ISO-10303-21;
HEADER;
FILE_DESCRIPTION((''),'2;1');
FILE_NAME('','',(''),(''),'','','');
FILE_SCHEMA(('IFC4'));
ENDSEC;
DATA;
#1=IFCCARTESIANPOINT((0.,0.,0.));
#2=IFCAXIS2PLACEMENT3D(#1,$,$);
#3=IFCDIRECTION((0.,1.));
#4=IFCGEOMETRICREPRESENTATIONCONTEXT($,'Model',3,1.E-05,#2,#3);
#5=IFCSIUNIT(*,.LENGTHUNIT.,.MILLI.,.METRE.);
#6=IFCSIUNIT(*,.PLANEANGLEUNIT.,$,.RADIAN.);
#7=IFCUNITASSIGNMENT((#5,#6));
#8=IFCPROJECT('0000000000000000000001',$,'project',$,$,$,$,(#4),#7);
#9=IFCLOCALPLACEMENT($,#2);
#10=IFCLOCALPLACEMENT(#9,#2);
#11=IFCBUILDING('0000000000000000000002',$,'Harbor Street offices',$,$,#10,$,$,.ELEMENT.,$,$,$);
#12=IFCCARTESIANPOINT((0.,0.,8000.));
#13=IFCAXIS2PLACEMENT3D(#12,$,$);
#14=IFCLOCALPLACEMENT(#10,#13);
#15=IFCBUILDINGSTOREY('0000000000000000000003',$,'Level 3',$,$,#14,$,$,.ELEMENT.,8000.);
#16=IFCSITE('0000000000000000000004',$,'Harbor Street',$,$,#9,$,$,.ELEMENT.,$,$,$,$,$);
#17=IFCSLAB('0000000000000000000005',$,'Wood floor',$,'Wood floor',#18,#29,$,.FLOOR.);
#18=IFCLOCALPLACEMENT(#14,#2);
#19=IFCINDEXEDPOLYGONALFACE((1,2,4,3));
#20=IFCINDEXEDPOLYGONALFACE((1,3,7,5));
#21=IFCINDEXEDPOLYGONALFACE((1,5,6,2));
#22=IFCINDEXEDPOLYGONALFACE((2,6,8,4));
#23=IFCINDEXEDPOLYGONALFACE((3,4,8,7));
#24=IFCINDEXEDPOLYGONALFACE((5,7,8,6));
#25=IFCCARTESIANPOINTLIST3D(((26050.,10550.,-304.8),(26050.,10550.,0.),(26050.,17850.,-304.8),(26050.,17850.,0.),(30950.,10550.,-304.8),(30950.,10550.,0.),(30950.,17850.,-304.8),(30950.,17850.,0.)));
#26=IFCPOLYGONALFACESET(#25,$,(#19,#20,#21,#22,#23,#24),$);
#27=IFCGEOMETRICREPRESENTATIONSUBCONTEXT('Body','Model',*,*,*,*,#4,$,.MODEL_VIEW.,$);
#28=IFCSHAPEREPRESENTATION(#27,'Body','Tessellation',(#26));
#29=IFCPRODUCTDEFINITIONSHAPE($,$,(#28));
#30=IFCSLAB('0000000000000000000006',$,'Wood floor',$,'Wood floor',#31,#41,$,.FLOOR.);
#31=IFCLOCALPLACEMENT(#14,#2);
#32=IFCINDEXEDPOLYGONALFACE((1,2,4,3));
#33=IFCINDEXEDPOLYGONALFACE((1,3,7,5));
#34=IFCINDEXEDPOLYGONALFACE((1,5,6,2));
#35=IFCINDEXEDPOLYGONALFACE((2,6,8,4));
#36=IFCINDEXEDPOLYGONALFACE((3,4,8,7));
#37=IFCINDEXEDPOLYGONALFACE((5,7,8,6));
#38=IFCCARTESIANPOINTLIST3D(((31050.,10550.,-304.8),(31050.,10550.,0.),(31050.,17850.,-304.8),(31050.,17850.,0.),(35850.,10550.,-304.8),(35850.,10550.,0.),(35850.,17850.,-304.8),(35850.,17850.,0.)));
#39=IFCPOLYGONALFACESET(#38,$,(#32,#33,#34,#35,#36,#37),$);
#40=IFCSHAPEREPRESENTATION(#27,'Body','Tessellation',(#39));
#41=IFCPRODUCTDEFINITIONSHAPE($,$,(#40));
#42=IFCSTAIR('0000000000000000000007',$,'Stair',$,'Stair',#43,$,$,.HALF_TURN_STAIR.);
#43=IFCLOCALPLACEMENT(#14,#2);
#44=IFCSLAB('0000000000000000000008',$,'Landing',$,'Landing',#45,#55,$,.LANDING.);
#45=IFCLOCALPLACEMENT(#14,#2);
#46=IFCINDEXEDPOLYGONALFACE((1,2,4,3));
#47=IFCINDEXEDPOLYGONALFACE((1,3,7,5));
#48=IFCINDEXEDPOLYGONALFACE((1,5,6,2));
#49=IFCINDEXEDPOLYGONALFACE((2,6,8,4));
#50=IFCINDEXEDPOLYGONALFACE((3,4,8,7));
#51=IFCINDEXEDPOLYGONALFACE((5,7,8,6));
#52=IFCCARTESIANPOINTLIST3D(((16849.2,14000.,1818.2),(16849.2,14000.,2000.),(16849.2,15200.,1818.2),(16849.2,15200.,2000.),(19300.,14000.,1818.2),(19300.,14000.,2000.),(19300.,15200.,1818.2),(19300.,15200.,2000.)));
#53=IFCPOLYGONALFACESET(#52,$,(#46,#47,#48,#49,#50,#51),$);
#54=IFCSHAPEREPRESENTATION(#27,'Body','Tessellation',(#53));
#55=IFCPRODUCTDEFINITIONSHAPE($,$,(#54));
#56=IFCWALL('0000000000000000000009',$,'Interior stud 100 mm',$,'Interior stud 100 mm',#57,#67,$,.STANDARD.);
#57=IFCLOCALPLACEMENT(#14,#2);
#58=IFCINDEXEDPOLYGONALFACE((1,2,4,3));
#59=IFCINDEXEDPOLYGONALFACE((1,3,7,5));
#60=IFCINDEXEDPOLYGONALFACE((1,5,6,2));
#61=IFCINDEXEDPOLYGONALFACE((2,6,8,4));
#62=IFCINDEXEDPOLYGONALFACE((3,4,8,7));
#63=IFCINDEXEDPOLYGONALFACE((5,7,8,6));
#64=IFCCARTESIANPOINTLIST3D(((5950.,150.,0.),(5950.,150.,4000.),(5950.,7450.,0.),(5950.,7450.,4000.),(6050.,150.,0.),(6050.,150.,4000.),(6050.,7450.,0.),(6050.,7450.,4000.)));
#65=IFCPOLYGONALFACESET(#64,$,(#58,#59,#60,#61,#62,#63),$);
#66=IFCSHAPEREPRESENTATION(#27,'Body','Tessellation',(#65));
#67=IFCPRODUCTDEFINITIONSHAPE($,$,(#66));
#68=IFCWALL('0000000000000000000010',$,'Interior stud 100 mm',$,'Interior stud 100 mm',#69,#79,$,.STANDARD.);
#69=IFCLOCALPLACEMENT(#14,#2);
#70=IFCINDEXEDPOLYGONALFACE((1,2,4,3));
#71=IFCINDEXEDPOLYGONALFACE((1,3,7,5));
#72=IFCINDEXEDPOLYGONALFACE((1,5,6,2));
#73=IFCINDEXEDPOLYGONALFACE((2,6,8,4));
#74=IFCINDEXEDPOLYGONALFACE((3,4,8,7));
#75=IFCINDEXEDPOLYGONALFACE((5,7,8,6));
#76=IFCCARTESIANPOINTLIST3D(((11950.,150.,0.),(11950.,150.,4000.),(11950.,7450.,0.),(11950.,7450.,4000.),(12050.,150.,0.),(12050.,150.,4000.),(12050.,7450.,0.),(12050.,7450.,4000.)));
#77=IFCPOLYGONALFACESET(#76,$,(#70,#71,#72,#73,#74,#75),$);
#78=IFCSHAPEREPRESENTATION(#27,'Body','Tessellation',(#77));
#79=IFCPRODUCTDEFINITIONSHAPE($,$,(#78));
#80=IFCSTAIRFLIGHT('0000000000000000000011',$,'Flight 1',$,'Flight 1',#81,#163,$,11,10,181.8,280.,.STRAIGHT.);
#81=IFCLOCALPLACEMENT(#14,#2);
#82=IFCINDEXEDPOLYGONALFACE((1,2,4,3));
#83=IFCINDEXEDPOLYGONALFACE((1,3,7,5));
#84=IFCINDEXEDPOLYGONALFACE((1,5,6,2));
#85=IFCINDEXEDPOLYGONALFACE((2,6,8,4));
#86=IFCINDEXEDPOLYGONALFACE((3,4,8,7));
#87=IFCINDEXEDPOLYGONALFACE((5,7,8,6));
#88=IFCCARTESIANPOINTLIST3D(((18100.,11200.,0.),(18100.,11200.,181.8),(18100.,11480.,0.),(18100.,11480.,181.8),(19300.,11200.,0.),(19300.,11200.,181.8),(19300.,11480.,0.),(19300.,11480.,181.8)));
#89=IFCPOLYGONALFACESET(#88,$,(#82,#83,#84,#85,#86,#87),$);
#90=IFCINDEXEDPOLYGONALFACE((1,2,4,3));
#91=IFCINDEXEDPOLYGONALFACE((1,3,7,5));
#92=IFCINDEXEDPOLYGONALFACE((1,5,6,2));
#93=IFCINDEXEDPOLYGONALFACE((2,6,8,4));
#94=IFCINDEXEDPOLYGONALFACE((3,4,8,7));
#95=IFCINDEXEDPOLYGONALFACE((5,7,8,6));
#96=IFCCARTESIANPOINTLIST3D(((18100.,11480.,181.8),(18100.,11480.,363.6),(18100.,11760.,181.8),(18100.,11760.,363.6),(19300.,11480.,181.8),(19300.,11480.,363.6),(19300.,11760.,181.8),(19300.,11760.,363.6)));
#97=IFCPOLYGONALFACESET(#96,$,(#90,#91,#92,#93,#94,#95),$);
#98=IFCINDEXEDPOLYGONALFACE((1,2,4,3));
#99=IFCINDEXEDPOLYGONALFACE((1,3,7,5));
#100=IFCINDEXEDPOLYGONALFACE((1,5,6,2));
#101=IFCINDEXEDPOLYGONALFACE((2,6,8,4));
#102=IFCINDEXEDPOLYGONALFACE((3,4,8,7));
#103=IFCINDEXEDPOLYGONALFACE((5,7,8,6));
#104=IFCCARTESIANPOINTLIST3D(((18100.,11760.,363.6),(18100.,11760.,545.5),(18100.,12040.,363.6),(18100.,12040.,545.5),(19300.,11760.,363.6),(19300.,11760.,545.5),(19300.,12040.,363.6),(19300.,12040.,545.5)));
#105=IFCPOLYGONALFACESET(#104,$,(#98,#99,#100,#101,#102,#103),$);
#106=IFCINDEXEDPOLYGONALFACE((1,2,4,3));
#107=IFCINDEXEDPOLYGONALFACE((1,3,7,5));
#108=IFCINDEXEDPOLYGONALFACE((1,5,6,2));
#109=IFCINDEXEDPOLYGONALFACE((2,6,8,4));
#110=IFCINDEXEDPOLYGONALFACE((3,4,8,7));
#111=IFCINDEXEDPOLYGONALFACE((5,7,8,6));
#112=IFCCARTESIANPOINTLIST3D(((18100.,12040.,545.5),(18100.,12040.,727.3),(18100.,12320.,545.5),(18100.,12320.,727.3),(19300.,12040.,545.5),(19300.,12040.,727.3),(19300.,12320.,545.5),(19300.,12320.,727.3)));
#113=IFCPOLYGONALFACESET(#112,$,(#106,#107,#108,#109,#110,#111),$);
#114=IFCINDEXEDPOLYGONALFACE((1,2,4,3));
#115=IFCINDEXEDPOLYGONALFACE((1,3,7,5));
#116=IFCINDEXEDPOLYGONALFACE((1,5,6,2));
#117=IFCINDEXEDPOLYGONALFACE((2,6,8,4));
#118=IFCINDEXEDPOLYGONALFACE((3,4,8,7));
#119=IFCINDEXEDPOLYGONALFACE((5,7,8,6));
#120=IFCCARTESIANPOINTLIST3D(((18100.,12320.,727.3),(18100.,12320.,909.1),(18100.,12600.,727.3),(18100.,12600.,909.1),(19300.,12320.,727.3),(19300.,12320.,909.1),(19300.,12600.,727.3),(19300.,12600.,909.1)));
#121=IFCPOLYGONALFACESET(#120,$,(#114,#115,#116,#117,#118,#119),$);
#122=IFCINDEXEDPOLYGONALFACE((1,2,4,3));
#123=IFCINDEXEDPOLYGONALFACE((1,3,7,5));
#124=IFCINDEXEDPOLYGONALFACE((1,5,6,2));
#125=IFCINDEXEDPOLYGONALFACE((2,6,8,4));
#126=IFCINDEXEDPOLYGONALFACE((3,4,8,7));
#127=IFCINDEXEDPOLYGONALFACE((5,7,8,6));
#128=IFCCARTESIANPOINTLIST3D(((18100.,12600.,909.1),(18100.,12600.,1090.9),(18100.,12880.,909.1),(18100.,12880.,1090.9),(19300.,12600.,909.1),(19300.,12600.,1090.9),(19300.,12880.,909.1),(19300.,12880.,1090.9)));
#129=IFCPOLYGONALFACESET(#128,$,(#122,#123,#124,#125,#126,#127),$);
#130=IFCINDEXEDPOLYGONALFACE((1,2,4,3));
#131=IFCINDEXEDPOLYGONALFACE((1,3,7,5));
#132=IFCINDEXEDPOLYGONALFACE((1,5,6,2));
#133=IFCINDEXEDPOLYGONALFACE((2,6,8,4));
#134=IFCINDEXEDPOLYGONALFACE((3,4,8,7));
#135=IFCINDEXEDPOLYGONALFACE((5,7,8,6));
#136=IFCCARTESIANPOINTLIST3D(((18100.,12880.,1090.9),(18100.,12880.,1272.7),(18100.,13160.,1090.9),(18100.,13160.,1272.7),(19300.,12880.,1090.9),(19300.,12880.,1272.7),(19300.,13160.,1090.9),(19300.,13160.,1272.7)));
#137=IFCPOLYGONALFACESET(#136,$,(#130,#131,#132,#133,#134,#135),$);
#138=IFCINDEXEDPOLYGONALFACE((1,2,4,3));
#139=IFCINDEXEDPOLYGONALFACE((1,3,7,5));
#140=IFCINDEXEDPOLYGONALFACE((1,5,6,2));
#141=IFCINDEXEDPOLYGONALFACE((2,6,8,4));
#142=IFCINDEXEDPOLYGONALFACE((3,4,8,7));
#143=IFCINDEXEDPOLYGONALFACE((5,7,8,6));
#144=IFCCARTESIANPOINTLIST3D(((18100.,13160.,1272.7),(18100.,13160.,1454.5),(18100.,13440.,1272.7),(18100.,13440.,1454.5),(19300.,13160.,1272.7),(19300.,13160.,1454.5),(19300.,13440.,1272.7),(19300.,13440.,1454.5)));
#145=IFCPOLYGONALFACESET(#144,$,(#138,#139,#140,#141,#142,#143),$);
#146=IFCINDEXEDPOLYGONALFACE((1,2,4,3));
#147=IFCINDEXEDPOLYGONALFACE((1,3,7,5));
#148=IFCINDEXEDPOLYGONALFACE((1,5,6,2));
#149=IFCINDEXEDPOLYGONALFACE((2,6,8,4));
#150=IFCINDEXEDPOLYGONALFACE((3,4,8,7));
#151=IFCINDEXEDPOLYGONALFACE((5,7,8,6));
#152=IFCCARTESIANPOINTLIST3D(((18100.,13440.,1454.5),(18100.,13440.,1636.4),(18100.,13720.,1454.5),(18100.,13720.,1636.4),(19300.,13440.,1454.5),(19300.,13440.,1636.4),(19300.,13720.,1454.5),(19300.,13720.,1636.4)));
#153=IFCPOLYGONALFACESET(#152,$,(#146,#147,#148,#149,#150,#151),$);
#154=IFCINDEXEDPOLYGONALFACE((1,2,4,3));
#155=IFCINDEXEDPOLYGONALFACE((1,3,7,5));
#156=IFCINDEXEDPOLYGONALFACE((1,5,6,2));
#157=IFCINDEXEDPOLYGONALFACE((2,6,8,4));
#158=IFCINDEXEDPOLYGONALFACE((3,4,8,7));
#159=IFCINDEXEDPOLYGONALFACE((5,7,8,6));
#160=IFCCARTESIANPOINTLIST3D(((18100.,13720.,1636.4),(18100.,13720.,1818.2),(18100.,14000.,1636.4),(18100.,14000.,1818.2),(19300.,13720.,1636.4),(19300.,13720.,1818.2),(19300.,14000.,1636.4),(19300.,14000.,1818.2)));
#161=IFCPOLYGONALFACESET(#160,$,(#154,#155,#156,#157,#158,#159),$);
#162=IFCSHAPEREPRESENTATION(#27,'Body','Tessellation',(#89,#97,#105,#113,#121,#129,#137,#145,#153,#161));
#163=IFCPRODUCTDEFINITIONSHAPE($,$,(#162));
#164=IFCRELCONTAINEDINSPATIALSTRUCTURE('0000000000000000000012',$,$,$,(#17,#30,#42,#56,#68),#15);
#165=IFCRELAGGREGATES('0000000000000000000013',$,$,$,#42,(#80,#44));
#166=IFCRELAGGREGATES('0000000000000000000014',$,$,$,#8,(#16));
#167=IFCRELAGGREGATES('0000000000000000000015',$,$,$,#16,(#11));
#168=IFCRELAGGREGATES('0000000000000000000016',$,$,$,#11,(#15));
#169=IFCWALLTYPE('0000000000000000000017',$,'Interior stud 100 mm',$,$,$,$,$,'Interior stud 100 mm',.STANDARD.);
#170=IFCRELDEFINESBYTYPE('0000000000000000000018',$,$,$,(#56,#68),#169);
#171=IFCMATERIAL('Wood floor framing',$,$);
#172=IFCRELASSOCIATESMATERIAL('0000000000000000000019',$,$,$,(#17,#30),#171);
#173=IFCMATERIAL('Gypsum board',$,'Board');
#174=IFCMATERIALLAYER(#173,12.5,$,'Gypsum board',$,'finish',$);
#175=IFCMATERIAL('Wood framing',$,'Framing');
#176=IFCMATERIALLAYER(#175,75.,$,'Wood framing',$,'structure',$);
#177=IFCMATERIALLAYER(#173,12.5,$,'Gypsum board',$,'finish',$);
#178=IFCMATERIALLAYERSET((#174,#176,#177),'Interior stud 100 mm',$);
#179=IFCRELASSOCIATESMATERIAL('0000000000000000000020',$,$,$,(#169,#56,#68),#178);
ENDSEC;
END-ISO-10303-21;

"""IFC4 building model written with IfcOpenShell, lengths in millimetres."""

from ifc_helpers import new_model, si_unit, direction, frame, origin, origin_with_axes, place, context, subcontext, project, spatial, polyline, outline, extrude, material, layer, layer_set, layer_usage, type_object, element, aggregate, save


model = new_model("IFC4")

# Units and contexts
model_context = context("Model", 3, precision=1e-05, world=origin(), true_north=direction((0.0, 1.0)))
body_context = subcontext(model_context, "Body", "Model", "MODEL_VIEW")
ifc_project = project(units=[si_unit("LENGTHUNIT", "METRE", prefix="MILLI"), si_unit("PLANEANGLEUNIT", "RADIAN")], contexts=[model_context])

# Site, building, storey
site_placement = place(None, origin())
site = spatial("IfcSite", under=ifc_project, at=site_placement, Name="Harbor Street", CompositionType="ELEMENT")
building_placement = place(site_placement, origin())
building = spatial("IfcBuilding", under=site, at=building_placement, Name="Harbor Street offices", CompositionType="ELEMENT")
storey_placement = place(building_placement, frame((0.0, 0.0, 8000.0)))
storey = spatial("IfcBuildingStorey", under=building, at=storey_placement, Name="Level 3", CompositionType="ELEMENT", Elevation=8000.0)

# Slabs
ifc_material_1 = material(Name="Wood floor framing")
slab_1_placement = place(storey_placement, origin_with_axes())
element("IfcSlab", 1, at=slab_1_placement, inside=storey, material=ifc_material_1, Name="Wood floor", ObjectType="Wood floor", PredefinedType="FLOOR", context=body_context, shape_type="SweptSolid", body=[
    extrude(outline(polyline([(30950.0, 17850.0), (26050.0, 17850.0), (26050.0, 10550.0), (30950.0, 10550.0), (30950.0, 17850.0)])), frame((0.0, 0.0, -304.8)), (0.0, 0.0, 1.0), 304.8),
])
slab_2_placement = place(storey_placement, origin_with_axes())
element("IfcSlab", 2, at=slab_2_placement, inside=storey, material=ifc_material_1, Name="Wood floor", ObjectType="Wood floor", PredefinedType="FLOOR", context=body_context, shape_type="SweptSolid", body=[
    extrude(outline(polyline([(35850.0, 10550.0), (35850.0, 17850.0), (31050.0, 17850.0), (31050.0, 10550.0), (35850.0, 10550.0)])), frame((0.0, 0.0, -304.8)), (0.0, 0.0, 1.0), 304.8),
])

# Stair, slab
stair_placement = place(storey_placement, origin_with_axes())
stair = element("IfcStair", 3, at=stair_placement, inside=storey, Name="Stair", ObjectType="Stair", PredefinedType="HALF_TURN_STAIR")
slab_3_placement = place(storey_placement, origin_with_axes())
slab_3 = element("IfcSlab", 4, at=slab_3_placement, Name="Landing", ObjectType="Landing", PredefinedType="LANDING", context=body_context, shape_type="SweptSolid", body=[
    extrude(outline(polyline([(19300.0, 14000.0), (19300.0, 15200.0), (16849.2, 15200.0), (16849.2, 14000.0), (19300.0, 14000.0)])), frame((0.0, 0.0, 1818.2)), (0.0, 0.0, 1.0), 181.8),
])

# Walls
ifc_material_2 = material(Name="Gypsum board", Category="Board")
ifc_layer_1 = layer(ifc_material_2, 12.5, Name="Gypsum board", Category="finish")
ifc_material_3 = material(Name="Wood framing", Category="Framing")
ifc_layer_2 = layer(ifc_material_3, 75.0, Name="Wood framing", Category="structure")
ifc_layer_3 = layer(ifc_material_2, 12.5, Name="Gypsum board", Category="finish")
ifc_layer_set = layer_set([ifc_layer_1, ifc_layer_2, ifc_layer_3], Name="Interior stud 100 mm")
ifc_layer_usage_1 = layer_usage(ifc_layer_set, "AXIS2", "NEGATIVE", 50.0)
wall_type = type_object("IfcWallType", Name="Interior stud 100 mm", ElementType="Interior stud 100 mm", PredefinedType="STANDARD", material=ifc_layer_set)
wall_1_placement = place(storey_placement, frame((6000.0, 0.0, 0.0), z_axis=(0.0, 0.0, 1.0), x_axis=(0.0, 1.0, 0.0)))
element("IfcWall", 5, at=wall_1_placement, inside=storey, type_object=wall_type, material=ifc_layer_usage_1, Name="Interior stud 100 mm", ObjectType="Interior stud 100 mm", PredefinedType="STANDARD", context=body_context, shape_type="SweptSolid", body=[
    extrude(outline(polyline([(150.0, -50.0), (7450.0, -50.0), (7450.0, 50.0), (150.0, 50.0), (150.0, -50.0)])), origin(), (0.0, 0.0, 1.0), 4000.0),
])
ifc_layer_usage_2 = layer_usage(ifc_layer_set, "AXIS2", "NEGATIVE", 50.0)
wall_2_placement = place(storey_placement, frame((12000.0, 0.0, 0.0), z_axis=(0.0, 0.0, 1.0), x_axis=(0.0, 1.0, 0.0)))
element("IfcWall", 6, at=wall_2_placement, inside=storey, type_object=wall_type, material=ifc_layer_usage_2, Name="Interior stud 100 mm", ObjectType="Interior stud 100 mm", PredefinedType="STANDARD", context=body_context, shape_type="SweptSolid", body=[
    extrude(outline(polyline([(150.0, -50.0), (7450.0, -50.0), (7450.0, 50.0), (150.0, 50.0), (150.0, -50.0)])), origin(), (0.0, 0.0, 1.0), 4000.0),
])

# Stair flight
stair_flight_1_placement = place(storey_placement, origin_with_axes())
stair_flight_1 = element("IfcStairFlight", 7, at=stair_flight_1_placement, Name="Flight 1", ObjectType="Flight 1", NumberOfRisers=11, NumberOfTreads=10, PredefinedType="STRAIGHT", RiserHeight=181.8, TreadLength=280.0, context=body_context, shape_type="SweptSolid", body=[
    extrude(outline(polyline([(19300.0, 11200.0), (19300.0, 11480.0), (18100.0, 11480.0), (18100.0, 11200.0), (19300.0, 11200.0)])), origin(), (0.0, 0.0, 1.0), 181.8),
    extrude(outline(polyline([(19300.0, 11480.0), (19300.0, 11760.0), (18100.0, 11760.0), (18100.0, 11480.0), (19300.0, 11480.0)])), frame((0.0, 0.0, 181.8)), (0.0, 0.0, 1.0), 181.8),
    extrude(outline(polyline([(19300.0, 11760.0), (19300.0, 12040.0), (18100.0, 12040.0), (18100.0, 11760.0), (19300.0, 11760.0)])), frame((0.0, 0.0, 363.6)), (0.0, 0.0, 1.0), 181.8),
    extrude(outline(polyline([(19300.0, 12040.0), (19300.0, 12320.0), (18100.0, 12320.0), (18100.0, 12040.0), (19300.0, 12040.0)])), frame((0.0, 0.0, 545.5)), (0.0, 0.0, 1.0), 181.8),
    extrude(outline(polyline([(19300.0, 12320.0), (19300.0, 12600.0), (18100.0, 12600.0), (18100.0, 12320.0), (19300.0, 12320.0)])), frame((0.0, 0.0, 727.3)), (0.0, 0.0, 1.0), 181.8),
    extrude(outline(polyline([(19300.0, 12600.0), (19300.0, 12880.0), (18100.0, 12880.0), (18100.0, 12600.0), (19300.0, 12600.0)])), frame((0.0, 0.0, 909.1)), (0.0, 0.0, 1.0), 181.8),
    extrude(outline(polyline([(19300.0, 12880.0), (19300.0, 13160.0), (18100.0, 13160.0), (18100.0, 12880.0), (19300.0, 12880.0)])), frame((0.0, 0.0, 1090.9)), (0.0, 0.0, 1.0), 181.8),
    extrude(outline(polyline([(19300.0, 13160.0), (19300.0, 13440.0), (18100.0, 13440.0), (18100.0, 13160.0), (19300.0, 13160.0)])), frame((0.0, 0.0, 1272.7)), (0.0, 0.0, 1.0), 181.8),
    extrude(outline(polyline([(19300.0, 13440.0), (19300.0, 13720.0), (18100.0, 13720.0), (18100.0, 13440.0), (19300.0, 13440.0)])), frame((0.0, 0.0, 1454.5)), (0.0, 0.0, 1.0), 181.8),
    extrude(outline(polyline([(19300.0, 13720.0), (19300.0, 14000.0), (18100.0, 14000.0), (18100.0, 13720.0), (19300.0, 13720.0)])), frame((0.0, 0.0, 1636.4)), (0.0, 0.0, 1.0), 181.8),
])

aggregate(stair, [stair_flight_1, slab_3])

save(model, "model.ifc")
